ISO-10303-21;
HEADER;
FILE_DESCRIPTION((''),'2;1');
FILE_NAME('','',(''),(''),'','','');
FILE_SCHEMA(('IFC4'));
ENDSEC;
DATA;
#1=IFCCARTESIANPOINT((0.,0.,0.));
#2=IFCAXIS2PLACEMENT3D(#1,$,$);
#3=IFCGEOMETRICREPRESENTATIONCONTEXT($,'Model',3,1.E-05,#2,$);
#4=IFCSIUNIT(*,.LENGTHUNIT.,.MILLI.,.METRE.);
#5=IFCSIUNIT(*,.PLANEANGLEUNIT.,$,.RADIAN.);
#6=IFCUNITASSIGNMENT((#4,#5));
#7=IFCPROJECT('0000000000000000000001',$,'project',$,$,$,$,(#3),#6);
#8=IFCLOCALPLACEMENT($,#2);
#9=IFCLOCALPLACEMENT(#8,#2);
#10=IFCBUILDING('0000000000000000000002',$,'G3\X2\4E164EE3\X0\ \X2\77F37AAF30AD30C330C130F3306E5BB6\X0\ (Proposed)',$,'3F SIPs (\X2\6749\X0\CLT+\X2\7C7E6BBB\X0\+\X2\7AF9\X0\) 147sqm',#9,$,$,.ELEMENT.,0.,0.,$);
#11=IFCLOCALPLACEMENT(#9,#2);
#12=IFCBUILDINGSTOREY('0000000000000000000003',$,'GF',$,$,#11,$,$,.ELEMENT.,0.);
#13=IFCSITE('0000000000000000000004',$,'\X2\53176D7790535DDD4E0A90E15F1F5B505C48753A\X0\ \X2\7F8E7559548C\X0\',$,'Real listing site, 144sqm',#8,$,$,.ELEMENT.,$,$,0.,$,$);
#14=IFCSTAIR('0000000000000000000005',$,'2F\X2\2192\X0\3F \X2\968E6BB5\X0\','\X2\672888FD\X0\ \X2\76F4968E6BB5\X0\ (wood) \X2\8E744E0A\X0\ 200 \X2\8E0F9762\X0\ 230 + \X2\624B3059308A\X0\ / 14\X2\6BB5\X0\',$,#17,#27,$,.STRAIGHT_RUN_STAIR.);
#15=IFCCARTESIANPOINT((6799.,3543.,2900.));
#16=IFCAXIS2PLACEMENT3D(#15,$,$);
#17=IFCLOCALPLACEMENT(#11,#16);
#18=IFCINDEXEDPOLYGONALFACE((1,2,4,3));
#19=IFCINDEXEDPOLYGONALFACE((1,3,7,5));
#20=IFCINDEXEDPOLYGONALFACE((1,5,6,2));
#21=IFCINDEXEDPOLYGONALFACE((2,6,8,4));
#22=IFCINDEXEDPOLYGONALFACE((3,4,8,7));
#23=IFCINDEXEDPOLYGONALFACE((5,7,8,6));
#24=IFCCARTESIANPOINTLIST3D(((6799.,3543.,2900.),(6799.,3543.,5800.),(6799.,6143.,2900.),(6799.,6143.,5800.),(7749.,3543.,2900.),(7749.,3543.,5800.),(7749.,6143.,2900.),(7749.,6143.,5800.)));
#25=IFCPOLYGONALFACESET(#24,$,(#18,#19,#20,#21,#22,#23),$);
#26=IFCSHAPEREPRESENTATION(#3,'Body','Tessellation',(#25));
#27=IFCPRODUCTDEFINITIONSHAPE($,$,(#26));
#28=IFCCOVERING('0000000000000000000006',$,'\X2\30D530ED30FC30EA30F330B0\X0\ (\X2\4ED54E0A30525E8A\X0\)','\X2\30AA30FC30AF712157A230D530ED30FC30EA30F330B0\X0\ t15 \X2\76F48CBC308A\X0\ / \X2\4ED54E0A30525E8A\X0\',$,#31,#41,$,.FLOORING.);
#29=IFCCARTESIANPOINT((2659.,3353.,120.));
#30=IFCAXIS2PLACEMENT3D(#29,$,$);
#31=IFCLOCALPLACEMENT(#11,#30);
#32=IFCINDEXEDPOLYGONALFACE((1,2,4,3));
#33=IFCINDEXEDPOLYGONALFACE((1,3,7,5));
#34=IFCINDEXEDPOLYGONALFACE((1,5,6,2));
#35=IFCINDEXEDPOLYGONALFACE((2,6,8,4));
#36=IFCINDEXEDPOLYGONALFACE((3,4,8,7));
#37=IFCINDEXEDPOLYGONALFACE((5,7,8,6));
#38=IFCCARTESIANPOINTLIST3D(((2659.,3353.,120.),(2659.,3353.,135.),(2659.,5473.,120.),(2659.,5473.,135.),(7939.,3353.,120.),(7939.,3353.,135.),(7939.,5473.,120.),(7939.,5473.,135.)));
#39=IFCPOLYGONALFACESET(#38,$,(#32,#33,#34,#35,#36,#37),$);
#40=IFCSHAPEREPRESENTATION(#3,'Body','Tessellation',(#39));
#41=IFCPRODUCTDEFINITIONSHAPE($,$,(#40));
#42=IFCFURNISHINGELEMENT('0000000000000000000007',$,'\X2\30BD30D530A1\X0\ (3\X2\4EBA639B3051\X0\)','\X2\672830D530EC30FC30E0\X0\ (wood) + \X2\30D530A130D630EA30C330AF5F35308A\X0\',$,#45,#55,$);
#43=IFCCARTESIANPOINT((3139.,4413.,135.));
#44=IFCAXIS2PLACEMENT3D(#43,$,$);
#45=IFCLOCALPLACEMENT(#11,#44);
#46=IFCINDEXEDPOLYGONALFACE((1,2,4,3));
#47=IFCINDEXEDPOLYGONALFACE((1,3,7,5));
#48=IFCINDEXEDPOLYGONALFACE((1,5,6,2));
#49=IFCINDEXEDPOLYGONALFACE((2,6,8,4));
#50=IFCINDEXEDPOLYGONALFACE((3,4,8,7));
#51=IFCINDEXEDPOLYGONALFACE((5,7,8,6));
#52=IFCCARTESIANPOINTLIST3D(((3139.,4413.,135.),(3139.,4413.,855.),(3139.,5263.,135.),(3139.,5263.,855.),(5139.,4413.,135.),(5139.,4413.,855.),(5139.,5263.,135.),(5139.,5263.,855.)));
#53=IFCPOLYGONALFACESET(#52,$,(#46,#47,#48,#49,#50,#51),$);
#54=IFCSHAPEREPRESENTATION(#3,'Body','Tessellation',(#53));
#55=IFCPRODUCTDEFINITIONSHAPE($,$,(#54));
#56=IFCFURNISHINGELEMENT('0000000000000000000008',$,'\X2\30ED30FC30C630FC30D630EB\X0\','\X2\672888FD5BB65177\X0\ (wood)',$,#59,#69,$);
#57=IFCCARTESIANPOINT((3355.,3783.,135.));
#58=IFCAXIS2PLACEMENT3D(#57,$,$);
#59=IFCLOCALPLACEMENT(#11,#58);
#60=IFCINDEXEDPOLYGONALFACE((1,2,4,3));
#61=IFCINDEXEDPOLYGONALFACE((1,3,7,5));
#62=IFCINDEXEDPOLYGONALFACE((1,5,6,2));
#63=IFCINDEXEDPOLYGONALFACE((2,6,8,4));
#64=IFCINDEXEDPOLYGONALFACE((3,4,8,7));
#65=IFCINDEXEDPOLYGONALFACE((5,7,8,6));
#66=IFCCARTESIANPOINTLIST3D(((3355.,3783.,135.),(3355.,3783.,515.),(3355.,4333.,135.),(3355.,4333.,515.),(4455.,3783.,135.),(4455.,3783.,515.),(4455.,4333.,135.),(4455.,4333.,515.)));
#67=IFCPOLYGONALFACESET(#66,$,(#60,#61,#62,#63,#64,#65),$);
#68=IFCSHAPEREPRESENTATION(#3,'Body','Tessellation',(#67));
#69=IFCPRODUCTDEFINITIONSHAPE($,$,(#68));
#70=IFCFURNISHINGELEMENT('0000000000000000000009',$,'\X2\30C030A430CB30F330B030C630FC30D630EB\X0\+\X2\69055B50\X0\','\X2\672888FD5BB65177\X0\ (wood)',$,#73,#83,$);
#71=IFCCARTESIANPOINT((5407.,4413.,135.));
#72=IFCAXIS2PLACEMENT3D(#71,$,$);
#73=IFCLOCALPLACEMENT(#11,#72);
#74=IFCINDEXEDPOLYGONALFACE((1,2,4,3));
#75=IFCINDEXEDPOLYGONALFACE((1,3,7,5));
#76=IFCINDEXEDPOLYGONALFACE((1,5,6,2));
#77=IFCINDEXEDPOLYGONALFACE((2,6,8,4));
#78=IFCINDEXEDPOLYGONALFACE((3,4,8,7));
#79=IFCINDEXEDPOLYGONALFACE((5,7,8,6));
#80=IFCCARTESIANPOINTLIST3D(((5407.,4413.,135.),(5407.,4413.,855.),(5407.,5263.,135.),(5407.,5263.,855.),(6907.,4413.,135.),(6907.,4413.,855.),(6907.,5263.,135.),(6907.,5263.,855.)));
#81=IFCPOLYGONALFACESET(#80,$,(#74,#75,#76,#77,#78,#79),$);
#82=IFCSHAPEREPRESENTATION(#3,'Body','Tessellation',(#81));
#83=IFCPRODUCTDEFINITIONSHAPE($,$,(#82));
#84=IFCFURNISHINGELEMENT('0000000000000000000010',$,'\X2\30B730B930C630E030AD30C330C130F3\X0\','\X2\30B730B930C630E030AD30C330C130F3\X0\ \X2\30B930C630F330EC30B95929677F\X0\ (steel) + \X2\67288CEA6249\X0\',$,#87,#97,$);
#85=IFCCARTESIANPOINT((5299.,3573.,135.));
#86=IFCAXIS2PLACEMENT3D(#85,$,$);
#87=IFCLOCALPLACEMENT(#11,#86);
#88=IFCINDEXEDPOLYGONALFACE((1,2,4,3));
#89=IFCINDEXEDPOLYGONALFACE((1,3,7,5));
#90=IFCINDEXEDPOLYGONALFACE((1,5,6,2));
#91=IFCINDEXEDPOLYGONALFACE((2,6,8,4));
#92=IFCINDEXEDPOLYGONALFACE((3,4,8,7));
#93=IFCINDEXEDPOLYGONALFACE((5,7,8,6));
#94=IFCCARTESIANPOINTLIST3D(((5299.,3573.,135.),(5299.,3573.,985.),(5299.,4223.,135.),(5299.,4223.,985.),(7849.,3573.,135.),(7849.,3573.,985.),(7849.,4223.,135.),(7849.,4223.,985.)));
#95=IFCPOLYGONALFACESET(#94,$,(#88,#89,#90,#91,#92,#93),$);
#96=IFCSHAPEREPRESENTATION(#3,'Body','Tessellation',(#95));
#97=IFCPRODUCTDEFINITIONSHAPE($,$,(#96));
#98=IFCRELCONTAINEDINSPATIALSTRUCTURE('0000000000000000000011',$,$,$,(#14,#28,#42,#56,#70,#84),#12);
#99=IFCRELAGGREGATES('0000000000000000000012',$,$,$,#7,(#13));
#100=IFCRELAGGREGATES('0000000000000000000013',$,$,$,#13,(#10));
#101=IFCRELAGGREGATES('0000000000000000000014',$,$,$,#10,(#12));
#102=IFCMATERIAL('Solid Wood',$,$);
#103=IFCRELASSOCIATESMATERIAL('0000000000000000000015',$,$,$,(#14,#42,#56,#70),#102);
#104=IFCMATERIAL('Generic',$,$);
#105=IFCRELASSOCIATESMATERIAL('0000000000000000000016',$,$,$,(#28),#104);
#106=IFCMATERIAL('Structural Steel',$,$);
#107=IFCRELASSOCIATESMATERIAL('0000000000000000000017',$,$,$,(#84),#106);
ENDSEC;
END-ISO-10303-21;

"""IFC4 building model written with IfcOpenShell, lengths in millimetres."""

from ifc_helpers import new_model, si_unit, frame, frame_2d, origin, place, context, project, spatial, rectangle, extrude, material, element, save


model = new_model("IFC4")

# Units and contexts
model_context = context("Model", 3, precision=1e-05, world=origin())
ifc_project = project(units=[si_unit("LENGTHUNIT", "METRE", prefix="MILLI"), si_unit("PLANEANGLEUNIT", "RADIAN")], contexts=[model_context])

# Site, building, storey
site_placement = place(None, origin())
site = spatial("IfcSite", under=ifc_project, at=site_placement, Name="北海道川上郡弟子屈町 美留和", ObjectType="Real listing site, 144sqm", CompositionType="ELEMENT", RefElevation=0.0)
building_placement = place(site_placement, origin())
building = spatial("IfcBuilding", under=site, at=building_placement, Name="G3世代 石窯キッチンの家 (Proposed)", ObjectType="3F SIPs (杉CLT+籾殻+竹) 147sqm", CompositionType="ELEMENT", ElevationOfRefHeight=0.0, ElevationOfTerrain=0.0)
storey_placement = place(building_placement, origin())
storey = spatial("IfcBuildingStorey", under=building, at=storey_placement, Name="GF", CompositionType="ELEMENT", Elevation=0.0)

# Shared definitions
ifc_material_1 = material(Name="Solid Wood")
ifc_material_2 = material(Name="Generic")

# Stair
stair_1_placement = place(storey_placement, frame((6799.0, 3543.0, 2900.0)))
element("IfcStair", 1, at=stair_1_placement, inside=storey, material=ifc_material_1, Name="2F→3F 階段", Description="木製 直階段 (wood) 蹴上 200 踏面 230 + 手すり / 14段", PredefinedType="STRAIGHT_RUN_STAIR", context=model_context, shape_type="SweptSolid", body=[
    extrude(rectangle(XDim=950.0, YDim=2600.0, at=frame_2d((475.0, 1300.0))), frame((6799.0, 3543.0, 2900.0)), (0.0, 0.0, 1.0), 2900.0),
])

# Covering
covering_placement = place(storey_placement, frame((2659.0, 3353.0, 120.0)))
element("IfcCovering", 2, at=covering_placement, inside=storey, material=ifc_material_2, Name="フローリング (仕上げ床)", Description="オーク無垢フローリング t15 直貼り / 仕上げ床", PredefinedType="FLOORING", context=model_context, shape_type="SweptSolid", body=[
    extrude(rectangle(XDim=5280.0, YDim=2120.0, at=frame_2d((2640.0, 1060.0))), frame((2659.0, 3353.0, 120.0)), (0.0, 0.0, 1.0), 15.0),
])

# Furnishing elements
furnishing_1_placement = place(storey_placement, frame((3139.0, 4413.0, 135.0)))
element("IfcFurnishingElement", 3, at=furnishing_1_placement, inside=storey, material=ifc_material_1, Name="ソファ (3人掛け)", Description="木フレーム (wood) + ファブリック張り", context=model_context, shape_type="SweptSolid", body=[
    extrude(rectangle(XDim=2000.0, YDim=850.0, at=frame_2d((1000.0, 425.0))), frame((3139.0, 4413.0, 135.0)), (0.0, 0.0, 1.0), 720.0),
])
furnishing_2_placement = place(storey_placement, frame((3355.0, 3783.0, 135.0)))
element("IfcFurnishingElement", 4, at=furnishing_2_placement, inside=storey, material=ifc_material_1, Name="ローテーブル", Description="木製家具 (wood)", context=model_context, shape_type="SweptSolid", body=[
    extrude(rectangle(XDim=1100.0, YDim=550.0, at=frame_2d((550.0, 275.0))), frame((3355.0, 3783.0, 135.0)), (0.0, 0.0, 1.0), 380.0),
])
furnishing_3_placement = place(storey_placement, frame((5407.0, 4413.0, 135.0)))
element("IfcFurnishingElement", 5, at=furnishing_3_placement, inside=storey, material=ifc_material_1, Name="ダイニングテーブル+椅子", Description="木製家具 (wood)", context=model_context, shape_type="SweptSolid", body=[
    extrude(rectangle(XDim=1500.0, YDim=850.0, at=frame_2d((750.0, 425.0))), frame((5407.0, 4413.0, 135.0)), (0.0, 0.0, 1.0), 720.0),
])
ifc_material_3 = material(Name="Structural Steel")
furnishing_4_placement = place(storey_placement, frame((5299.0, 3573.0, 135.0)))
element("IfcFurnishingElement", 6, at=furnishing_4_placement, inside=storey, material=ifc_material_3, Name="システムキッチン", Description="システムキッチン ステンレス天板 (steel) + 木質扉", context=model_context, shape_type="SweptSolid", body=[
    extrude(rectangle(XDim=2550.0, YDim=650.0, at=frame_2d((1275.0, 325.0))), frame((5299.0, 3573.0, 135.0)), (0.0, 0.0, 1.0), 850.0),
])

save(model, "model.ifc")
